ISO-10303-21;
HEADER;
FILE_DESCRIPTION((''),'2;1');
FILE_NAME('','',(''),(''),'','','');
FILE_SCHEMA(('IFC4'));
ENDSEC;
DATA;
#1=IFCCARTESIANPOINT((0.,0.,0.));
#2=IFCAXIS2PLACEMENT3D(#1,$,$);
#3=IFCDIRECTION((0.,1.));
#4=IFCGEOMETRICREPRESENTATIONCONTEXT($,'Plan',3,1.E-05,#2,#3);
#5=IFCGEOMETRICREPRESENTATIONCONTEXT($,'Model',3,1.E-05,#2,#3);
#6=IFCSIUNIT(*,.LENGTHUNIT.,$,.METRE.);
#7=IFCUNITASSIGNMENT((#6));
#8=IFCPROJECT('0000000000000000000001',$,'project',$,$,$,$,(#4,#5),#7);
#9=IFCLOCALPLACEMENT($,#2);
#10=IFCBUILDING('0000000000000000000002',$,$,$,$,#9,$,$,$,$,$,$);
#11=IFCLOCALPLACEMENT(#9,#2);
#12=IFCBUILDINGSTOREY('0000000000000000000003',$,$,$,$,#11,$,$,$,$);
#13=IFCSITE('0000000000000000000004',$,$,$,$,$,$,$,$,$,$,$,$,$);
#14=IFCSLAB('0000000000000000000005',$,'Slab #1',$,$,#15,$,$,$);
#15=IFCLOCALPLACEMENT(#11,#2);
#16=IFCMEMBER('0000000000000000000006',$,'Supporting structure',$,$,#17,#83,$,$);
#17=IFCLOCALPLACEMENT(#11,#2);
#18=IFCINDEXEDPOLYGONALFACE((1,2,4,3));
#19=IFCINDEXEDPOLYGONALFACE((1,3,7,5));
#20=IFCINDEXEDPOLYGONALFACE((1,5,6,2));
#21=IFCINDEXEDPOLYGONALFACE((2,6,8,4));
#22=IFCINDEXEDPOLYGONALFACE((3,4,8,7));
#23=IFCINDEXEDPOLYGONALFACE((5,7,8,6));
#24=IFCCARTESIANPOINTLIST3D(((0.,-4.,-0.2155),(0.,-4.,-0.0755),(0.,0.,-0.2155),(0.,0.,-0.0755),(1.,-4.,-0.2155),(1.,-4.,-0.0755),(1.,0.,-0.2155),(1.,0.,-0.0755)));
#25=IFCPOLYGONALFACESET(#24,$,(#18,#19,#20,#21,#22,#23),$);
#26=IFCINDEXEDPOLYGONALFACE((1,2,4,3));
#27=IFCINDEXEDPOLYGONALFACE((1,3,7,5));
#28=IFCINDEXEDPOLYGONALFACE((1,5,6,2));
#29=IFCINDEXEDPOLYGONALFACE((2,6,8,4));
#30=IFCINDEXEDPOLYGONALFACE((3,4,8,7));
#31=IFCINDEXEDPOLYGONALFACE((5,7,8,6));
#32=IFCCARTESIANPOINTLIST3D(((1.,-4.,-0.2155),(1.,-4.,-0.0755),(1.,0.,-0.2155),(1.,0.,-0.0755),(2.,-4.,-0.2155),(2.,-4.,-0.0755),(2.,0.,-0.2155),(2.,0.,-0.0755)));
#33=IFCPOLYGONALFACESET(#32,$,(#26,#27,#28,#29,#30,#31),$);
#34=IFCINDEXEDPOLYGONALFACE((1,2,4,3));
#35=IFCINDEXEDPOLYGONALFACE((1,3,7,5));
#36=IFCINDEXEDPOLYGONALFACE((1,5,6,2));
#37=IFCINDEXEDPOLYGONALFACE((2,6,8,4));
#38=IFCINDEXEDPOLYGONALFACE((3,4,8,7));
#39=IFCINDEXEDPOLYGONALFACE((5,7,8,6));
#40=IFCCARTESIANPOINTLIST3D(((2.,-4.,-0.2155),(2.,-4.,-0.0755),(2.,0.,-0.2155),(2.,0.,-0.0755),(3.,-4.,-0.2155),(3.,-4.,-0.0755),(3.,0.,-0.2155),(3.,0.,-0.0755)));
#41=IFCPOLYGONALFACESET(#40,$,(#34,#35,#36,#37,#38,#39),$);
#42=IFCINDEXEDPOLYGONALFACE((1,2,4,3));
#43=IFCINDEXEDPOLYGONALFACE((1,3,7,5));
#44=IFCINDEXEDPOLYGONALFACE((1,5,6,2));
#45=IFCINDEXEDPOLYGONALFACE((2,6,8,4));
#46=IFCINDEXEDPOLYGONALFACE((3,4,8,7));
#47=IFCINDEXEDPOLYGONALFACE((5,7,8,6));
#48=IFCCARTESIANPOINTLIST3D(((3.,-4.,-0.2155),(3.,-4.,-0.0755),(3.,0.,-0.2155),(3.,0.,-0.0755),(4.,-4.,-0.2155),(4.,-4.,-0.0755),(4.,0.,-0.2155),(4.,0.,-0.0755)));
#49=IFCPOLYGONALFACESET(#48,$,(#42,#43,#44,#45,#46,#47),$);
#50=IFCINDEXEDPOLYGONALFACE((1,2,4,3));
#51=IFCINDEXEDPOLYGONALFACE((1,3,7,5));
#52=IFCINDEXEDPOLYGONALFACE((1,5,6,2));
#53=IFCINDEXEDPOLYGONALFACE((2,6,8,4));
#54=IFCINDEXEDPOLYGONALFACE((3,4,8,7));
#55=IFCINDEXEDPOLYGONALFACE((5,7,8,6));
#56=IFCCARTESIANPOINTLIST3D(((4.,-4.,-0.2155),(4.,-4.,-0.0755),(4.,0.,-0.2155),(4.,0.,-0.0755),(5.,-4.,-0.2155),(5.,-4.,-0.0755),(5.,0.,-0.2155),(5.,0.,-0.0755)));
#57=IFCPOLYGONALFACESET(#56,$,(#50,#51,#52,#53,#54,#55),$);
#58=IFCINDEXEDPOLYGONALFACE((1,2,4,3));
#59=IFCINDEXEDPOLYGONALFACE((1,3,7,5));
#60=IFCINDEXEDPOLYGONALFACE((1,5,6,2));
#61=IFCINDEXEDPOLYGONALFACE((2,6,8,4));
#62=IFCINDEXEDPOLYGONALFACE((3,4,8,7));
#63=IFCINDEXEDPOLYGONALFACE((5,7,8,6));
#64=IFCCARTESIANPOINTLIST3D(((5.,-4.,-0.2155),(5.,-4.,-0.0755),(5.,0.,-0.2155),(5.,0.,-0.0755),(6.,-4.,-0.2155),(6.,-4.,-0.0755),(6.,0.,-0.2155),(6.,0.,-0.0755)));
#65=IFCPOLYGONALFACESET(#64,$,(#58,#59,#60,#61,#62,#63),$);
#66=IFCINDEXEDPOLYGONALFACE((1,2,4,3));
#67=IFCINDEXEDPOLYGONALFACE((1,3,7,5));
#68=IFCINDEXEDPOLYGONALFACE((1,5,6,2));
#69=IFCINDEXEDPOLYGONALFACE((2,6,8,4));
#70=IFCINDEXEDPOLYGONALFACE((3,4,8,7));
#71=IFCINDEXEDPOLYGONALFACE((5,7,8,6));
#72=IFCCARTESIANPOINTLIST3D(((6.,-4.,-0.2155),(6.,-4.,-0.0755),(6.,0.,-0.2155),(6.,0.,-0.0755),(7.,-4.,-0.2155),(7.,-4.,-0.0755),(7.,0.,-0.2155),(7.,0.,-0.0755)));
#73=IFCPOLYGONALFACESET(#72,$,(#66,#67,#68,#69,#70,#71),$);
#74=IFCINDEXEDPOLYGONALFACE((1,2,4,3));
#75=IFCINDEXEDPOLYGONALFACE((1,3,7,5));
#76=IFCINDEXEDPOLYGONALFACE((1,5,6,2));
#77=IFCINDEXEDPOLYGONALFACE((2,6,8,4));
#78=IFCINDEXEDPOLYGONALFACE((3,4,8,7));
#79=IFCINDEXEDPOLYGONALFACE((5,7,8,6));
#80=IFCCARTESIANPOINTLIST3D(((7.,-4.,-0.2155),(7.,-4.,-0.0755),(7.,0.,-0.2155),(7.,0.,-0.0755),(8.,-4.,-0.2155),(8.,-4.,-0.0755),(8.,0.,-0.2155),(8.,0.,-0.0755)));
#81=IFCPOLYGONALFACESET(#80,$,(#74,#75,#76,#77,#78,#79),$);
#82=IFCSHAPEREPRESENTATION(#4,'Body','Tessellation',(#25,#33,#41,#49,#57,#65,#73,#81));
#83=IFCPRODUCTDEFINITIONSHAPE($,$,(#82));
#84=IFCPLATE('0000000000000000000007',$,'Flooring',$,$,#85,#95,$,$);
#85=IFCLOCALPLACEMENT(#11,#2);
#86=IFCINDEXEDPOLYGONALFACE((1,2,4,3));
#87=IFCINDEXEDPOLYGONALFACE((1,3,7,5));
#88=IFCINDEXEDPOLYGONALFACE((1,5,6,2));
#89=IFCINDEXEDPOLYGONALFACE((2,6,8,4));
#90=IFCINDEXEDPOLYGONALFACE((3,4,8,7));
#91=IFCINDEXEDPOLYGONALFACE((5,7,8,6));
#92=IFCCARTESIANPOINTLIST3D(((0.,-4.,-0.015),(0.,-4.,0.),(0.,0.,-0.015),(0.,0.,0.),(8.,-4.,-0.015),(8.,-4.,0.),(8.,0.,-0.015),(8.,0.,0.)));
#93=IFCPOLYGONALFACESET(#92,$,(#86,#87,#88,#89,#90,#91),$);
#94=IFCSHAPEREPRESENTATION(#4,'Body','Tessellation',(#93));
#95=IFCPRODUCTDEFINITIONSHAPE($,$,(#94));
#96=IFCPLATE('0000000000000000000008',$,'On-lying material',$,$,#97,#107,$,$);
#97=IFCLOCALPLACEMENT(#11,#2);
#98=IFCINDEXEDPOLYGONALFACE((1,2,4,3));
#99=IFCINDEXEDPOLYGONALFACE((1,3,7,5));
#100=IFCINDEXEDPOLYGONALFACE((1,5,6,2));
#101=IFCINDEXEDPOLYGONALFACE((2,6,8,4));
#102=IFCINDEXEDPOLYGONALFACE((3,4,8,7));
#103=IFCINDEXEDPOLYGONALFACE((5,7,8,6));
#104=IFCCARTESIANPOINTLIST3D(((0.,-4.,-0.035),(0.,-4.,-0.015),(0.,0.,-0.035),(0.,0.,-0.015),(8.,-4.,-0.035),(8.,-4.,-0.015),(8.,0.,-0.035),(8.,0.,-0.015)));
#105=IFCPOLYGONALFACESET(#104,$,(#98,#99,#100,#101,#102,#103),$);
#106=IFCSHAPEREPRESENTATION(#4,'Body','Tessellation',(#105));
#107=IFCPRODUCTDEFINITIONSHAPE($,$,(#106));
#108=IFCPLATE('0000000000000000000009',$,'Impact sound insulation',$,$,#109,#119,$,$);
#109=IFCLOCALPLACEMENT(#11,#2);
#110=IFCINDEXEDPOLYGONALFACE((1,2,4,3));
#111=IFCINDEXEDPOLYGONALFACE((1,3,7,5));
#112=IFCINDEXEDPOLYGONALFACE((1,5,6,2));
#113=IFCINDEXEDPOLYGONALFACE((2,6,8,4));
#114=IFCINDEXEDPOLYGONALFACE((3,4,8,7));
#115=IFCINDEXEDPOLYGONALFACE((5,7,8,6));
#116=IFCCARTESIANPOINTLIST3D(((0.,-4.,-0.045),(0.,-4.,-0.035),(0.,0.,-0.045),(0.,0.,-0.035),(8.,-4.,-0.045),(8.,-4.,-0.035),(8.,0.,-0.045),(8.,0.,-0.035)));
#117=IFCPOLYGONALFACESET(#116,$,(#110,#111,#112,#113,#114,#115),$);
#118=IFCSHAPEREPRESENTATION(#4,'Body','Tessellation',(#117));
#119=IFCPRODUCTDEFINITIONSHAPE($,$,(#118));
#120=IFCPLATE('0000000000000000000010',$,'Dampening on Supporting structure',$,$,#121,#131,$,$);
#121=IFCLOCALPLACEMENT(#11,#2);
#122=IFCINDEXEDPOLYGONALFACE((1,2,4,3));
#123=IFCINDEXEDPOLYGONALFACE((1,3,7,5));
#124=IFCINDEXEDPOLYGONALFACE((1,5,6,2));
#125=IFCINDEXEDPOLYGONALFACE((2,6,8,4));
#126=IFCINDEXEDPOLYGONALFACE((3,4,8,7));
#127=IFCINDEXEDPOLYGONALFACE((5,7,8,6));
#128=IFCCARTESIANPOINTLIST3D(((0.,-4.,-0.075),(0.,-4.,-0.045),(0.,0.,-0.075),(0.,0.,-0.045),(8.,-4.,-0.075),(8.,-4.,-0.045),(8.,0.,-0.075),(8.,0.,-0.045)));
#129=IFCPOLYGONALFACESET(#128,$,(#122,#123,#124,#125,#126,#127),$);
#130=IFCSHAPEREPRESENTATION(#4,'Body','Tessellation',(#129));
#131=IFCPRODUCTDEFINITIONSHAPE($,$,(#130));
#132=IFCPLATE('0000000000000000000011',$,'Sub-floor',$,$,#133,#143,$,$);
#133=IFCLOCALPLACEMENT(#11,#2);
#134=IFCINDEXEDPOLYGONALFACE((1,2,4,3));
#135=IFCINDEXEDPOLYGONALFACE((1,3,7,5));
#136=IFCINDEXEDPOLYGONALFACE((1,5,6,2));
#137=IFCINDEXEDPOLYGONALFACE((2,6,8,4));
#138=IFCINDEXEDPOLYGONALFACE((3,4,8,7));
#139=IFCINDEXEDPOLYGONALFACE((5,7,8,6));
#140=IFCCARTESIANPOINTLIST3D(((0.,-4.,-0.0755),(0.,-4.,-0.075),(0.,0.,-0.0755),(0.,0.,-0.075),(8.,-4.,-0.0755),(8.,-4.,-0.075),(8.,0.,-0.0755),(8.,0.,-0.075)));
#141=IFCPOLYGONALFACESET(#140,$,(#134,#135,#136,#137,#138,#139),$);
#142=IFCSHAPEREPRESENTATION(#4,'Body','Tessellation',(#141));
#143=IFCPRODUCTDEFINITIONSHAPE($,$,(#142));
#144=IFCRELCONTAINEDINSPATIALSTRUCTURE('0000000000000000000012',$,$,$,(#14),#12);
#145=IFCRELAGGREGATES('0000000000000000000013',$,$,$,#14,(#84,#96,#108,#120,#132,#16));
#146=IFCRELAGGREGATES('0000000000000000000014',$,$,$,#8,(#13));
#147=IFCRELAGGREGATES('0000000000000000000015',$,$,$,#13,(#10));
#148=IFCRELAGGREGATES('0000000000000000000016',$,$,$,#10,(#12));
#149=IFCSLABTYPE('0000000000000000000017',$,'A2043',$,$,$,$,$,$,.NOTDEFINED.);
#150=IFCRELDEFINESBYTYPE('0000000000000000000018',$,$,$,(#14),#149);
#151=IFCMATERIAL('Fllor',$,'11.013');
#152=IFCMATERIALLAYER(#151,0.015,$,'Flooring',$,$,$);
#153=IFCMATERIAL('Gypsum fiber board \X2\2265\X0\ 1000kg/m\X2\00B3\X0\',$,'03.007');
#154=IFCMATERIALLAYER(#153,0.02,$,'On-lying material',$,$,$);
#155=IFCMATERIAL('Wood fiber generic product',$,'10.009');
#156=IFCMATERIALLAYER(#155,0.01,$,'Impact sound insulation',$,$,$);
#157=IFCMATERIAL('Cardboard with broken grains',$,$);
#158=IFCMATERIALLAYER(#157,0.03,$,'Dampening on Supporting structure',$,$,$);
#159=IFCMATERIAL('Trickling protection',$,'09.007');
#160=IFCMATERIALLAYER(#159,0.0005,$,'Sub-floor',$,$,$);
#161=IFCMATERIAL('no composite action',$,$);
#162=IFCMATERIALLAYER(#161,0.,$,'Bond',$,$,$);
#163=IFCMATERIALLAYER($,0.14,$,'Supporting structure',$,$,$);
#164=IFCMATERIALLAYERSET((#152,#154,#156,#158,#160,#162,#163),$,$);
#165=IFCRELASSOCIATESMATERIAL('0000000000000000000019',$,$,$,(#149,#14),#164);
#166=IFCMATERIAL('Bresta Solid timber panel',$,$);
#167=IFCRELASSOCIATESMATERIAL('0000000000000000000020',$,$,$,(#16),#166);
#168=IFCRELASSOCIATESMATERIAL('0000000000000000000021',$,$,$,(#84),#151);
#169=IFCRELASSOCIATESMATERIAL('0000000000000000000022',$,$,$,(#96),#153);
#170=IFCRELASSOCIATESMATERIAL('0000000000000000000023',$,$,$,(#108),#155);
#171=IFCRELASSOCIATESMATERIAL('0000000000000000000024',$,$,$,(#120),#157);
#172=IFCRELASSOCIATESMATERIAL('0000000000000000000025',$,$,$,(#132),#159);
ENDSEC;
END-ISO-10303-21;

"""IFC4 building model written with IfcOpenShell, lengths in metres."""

from ifc_helpers import new_model, si_unit, direction, frame, frame_2d, origin, origin_with_axes, place, context, project, spatial, rectangle, extrude, material, layer, layer_set, type_object, element, aggregate, save


model = new_model("IFC4")

# Units and contexts
plan_context = context("Plan", 3, precision=1e-05, world=origin(), true_north=direction((0.0, 1.0)))
model_context = context("Model", 3, precision=1e-05, world=origin(), true_north=direction((0.0, 1.0)))
ifc_project = project(units=[si_unit("LENGTHUNIT", "METRE")], contexts=[plan_context, model_context])

# Site, building, storey
site = spatial("IfcSite", under=ifc_project)
building_placement = place(None, origin())
building = spatial("IfcBuilding", under=site, at=building_placement)
storey_placement = place(building_placement, origin())
storey = spatial("IfcBuildingStorey", under=building, at=storey_placement)

# Slab, member, plates
ifc_material_1 = material(Name="Fllor", Category="11.013")
ifc_layer_1 = layer(ifc_material_1, 0.015, Name="Flooring")
ifc_material_2 = material(Name="Gypsum fiber board ≥ 1000kg/m³", Category="03.007")
ifc_layer_2 = layer(ifc_material_2, 0.02, Name="On-lying material")
ifc_material_3 = material(Name="Wood fiber generic product", Category="10.009")
ifc_layer_3 = layer(ifc_material_3, 0.01, Name="Impact sound insulation")
ifc_material_4 = material(Name="Cardboard with broken grains")
ifc_layer_4 = layer(ifc_material_4, 0.03, Name="Dampening on Supporting structure")
ifc_material_5 = material(Name="Trickling protection", Category="09.007")
ifc_layer_5 = layer(ifc_material_5, 0.0005, Name="Sub-floor")
ifc_material_6 = material(Name="no composite action")
ifc_layer_6 = layer(ifc_material_6, 0.0, Name="Bond")
ifc_layer_7 = layer(None, 0.14, Name="Supporting structure")
ifc_layer_set = layer_set([ifc_layer_1, ifc_layer_2, ifc_layer_3, ifc_layer_4, ifc_layer_5, ifc_layer_6, ifc_layer_7])
slab_type = type_object("IfcSlabType", Name="A2043", PredefinedType="NOTDEFINED", material=ifc_layer_set)
slab_placement = place(None, frame((0.0, 0.0, 0.0), z_axis=(0.0, 0.0, -1.0), x_axis=(1.0, 0.0, 0.0)))
slab = element("IfcSlab", 1, at=slab_placement, inside=storey, type_object=slab_type, material=ifc_layer_set, Name="Slab #1")
ifc_material_7 = material(Name="Bresta Solid timber panel")
member_placement = place(slab_placement, origin())
member = element("IfcMember", 2, at=member_placement, material=ifc_material_7, Name="Supporting structure", context=plan_context, shape_type="SweptSolid", body=[
    extrude(rectangle(XDim=1.0, YDim=0.14, at=frame_2d((0.5, 0.07), x_axis=(1.0, 0.0))), frame((0.0, 4.0, 0.0755), z_axis=(0.0, -1.0, 0.0), x_axis=(1.0, 0.0, 0.0)), (0.0, 0.0, 1.0), 4.0),
    extrude(rectangle(XDim=1.0, YDim=0.14, at=frame_2d((0.5, 0.07), x_axis=(1.0, 0.0))), frame((1.0, 4.0, 0.0755), z_axis=(0.0, -1.0, 0.0), x_axis=(1.0, 0.0, 0.0)), (0.0, 0.0, 1.0), 4.0),
    extrude(rectangle(XDim=1.0, YDim=0.14, at=frame_2d((0.5, 0.07), x_axis=(1.0, 0.0))), frame((2.0, 4.0, 0.0755), z_axis=(0.0, -1.0, 0.0), x_axis=(1.0, 0.0, 0.0)), (0.0, 0.0, 1.0), 4.0),
    extrude(rectangle(XDim=1.0, YDim=0.14, at=frame_2d((0.5, 0.07), x_axis=(1.0, 0.0))), frame((3.0, 4.0, 0.0755), z_axis=(0.0, -1.0, 0.0), x_axis=(1.0, 0.0, 0.0)), (0.0, 0.0, 1.0), 4.0),
    extrude(rectangle(XDim=1.0, YDim=0.14, at=frame_2d((0.5, 0.07), x_axis=(1.0, 0.0))), frame((4.0, 4.0, 0.0755), z_axis=(0.0, -1.0, 0.0), x_axis=(1.0, 0.0, 0.0)), (0.0, 0.0, 1.0), 4.0),
    extrude(rectangle(XDim=1.0, YDim=0.14, at=frame_2d((0.5, 0.07), x_axis=(1.0, 0.0))), frame((5.0, 4.0, 0.0755), z_axis=(0.0, -1.0, 0.0), x_axis=(1.0, 0.0, 0.0)), (0.0, 0.0, 1.0), 4.0),
    extrude(rectangle(XDim=1.0, YDim=0.14, at=frame_2d((0.5, 0.07), x_axis=(1.0, 0.0))), frame((6.0, 4.0, 0.0755), z_axis=(0.0, -1.0, 0.0), x_axis=(1.0, 0.0, 0.0)), (0.0, 0.0, 1.0), 4.0),
    extrude(rectangle(XDim=1.0, YDim=0.14, at=frame_2d((0.5, 0.07), x_axis=(1.0, 0.0))), frame((7.0, 4.0, 0.0755), z_axis=(0.0, -1.0, 0.0), x_axis=(1.0, 0.0, 0.0)), (0.0, 0.0, 1.0), 4.0),
])
plate_1_placement = place(slab_placement, origin())
plate_1 = element("IfcPlate", 3, at=plate_1_placement, material=ifc_material_1, Name="Flooring", context=plan_context, shape_type="SweptSolid", body=[
    extrude(rectangle(XDim=8.0, YDim=4.0, at=frame_2d((4.0, 2.0), x_axis=(1.0, 0.0))), origin_with_axes(), (0.0, 0.0, 1.0), 0.015),
])
plate_2_placement = place(slab_placement, origin())
plate_2 = element("IfcPlate", 4, at=plate_2_placement, material=ifc_material_2, Name="On-lying material", context=plan_context, shape_type="SweptSolid", body=[
    extrude(rectangle(XDim=8.0, YDim=4.0, at=frame_2d((4.0, 2.0), x_axis=(1.0, 0.0))), frame((0.0, 0.0, 0.015), z_axis=(0.0, 0.0, 1.0), x_axis=(1.0, 0.0, 0.0)), (0.0, 0.0, 1.0), 0.02),
])
plate_3_placement = place(slab_placement, origin())
plate_3 = element("IfcPlate", 5, at=plate_3_placement, material=ifc_material_3, Name="Impact sound insulation", context=plan_context, shape_type="SweptSolid", body=[
    extrude(rectangle(XDim=8.0, YDim=4.0, at=frame_2d((4.0, 2.0), x_axis=(1.0, 0.0))), frame((0.0, 0.0, 0.035), z_axis=(0.0, 0.0, 1.0), x_axis=(1.0, 0.0, 0.0)), (0.0, 0.0, 1.0), 0.01),
])
plate_4_placement = place(slab_placement, origin())
plate_4 = element("IfcPlate", 6, at=plate_4_placement, material=ifc_material_4, Name="Dampening on Supporting structure", context=plan_context, shape_type="SweptSolid", body=[
    extrude(rectangle(XDim=8.0, YDim=4.0, at=frame_2d((4.0, 2.0), x_axis=(1.0, 0.0))), frame((0.0, 0.0, 0.045), z_axis=(0.0, 0.0, 1.0), x_axis=(1.0, 0.0, 0.0)), (0.0, 0.0, 1.0), 0.03),
])
plate_5_placement = place(slab_placement, origin())
plate_5 = element("IfcPlate", 7, at=plate_5_placement, material=ifc_material_5, Name="Sub-floor", context=plan_context, shape_type="SweptSolid", body=[
    extrude(rectangle(XDim=8.0, YDim=4.0, at=frame_2d((4.0, 2.0), x_axis=(1.0, 0.0))), frame((0.0, 0.0, 0.075), z_axis=(0.0, 0.0, 1.0), x_axis=(1.0, 0.0, 0.0)), (0.0, 0.0, 1.0), 0.0005),
])
aggregate(slab, [plate_1, plate_2, plate_3, plate_4, plate_5, member])

save(model, "model.ifc")
